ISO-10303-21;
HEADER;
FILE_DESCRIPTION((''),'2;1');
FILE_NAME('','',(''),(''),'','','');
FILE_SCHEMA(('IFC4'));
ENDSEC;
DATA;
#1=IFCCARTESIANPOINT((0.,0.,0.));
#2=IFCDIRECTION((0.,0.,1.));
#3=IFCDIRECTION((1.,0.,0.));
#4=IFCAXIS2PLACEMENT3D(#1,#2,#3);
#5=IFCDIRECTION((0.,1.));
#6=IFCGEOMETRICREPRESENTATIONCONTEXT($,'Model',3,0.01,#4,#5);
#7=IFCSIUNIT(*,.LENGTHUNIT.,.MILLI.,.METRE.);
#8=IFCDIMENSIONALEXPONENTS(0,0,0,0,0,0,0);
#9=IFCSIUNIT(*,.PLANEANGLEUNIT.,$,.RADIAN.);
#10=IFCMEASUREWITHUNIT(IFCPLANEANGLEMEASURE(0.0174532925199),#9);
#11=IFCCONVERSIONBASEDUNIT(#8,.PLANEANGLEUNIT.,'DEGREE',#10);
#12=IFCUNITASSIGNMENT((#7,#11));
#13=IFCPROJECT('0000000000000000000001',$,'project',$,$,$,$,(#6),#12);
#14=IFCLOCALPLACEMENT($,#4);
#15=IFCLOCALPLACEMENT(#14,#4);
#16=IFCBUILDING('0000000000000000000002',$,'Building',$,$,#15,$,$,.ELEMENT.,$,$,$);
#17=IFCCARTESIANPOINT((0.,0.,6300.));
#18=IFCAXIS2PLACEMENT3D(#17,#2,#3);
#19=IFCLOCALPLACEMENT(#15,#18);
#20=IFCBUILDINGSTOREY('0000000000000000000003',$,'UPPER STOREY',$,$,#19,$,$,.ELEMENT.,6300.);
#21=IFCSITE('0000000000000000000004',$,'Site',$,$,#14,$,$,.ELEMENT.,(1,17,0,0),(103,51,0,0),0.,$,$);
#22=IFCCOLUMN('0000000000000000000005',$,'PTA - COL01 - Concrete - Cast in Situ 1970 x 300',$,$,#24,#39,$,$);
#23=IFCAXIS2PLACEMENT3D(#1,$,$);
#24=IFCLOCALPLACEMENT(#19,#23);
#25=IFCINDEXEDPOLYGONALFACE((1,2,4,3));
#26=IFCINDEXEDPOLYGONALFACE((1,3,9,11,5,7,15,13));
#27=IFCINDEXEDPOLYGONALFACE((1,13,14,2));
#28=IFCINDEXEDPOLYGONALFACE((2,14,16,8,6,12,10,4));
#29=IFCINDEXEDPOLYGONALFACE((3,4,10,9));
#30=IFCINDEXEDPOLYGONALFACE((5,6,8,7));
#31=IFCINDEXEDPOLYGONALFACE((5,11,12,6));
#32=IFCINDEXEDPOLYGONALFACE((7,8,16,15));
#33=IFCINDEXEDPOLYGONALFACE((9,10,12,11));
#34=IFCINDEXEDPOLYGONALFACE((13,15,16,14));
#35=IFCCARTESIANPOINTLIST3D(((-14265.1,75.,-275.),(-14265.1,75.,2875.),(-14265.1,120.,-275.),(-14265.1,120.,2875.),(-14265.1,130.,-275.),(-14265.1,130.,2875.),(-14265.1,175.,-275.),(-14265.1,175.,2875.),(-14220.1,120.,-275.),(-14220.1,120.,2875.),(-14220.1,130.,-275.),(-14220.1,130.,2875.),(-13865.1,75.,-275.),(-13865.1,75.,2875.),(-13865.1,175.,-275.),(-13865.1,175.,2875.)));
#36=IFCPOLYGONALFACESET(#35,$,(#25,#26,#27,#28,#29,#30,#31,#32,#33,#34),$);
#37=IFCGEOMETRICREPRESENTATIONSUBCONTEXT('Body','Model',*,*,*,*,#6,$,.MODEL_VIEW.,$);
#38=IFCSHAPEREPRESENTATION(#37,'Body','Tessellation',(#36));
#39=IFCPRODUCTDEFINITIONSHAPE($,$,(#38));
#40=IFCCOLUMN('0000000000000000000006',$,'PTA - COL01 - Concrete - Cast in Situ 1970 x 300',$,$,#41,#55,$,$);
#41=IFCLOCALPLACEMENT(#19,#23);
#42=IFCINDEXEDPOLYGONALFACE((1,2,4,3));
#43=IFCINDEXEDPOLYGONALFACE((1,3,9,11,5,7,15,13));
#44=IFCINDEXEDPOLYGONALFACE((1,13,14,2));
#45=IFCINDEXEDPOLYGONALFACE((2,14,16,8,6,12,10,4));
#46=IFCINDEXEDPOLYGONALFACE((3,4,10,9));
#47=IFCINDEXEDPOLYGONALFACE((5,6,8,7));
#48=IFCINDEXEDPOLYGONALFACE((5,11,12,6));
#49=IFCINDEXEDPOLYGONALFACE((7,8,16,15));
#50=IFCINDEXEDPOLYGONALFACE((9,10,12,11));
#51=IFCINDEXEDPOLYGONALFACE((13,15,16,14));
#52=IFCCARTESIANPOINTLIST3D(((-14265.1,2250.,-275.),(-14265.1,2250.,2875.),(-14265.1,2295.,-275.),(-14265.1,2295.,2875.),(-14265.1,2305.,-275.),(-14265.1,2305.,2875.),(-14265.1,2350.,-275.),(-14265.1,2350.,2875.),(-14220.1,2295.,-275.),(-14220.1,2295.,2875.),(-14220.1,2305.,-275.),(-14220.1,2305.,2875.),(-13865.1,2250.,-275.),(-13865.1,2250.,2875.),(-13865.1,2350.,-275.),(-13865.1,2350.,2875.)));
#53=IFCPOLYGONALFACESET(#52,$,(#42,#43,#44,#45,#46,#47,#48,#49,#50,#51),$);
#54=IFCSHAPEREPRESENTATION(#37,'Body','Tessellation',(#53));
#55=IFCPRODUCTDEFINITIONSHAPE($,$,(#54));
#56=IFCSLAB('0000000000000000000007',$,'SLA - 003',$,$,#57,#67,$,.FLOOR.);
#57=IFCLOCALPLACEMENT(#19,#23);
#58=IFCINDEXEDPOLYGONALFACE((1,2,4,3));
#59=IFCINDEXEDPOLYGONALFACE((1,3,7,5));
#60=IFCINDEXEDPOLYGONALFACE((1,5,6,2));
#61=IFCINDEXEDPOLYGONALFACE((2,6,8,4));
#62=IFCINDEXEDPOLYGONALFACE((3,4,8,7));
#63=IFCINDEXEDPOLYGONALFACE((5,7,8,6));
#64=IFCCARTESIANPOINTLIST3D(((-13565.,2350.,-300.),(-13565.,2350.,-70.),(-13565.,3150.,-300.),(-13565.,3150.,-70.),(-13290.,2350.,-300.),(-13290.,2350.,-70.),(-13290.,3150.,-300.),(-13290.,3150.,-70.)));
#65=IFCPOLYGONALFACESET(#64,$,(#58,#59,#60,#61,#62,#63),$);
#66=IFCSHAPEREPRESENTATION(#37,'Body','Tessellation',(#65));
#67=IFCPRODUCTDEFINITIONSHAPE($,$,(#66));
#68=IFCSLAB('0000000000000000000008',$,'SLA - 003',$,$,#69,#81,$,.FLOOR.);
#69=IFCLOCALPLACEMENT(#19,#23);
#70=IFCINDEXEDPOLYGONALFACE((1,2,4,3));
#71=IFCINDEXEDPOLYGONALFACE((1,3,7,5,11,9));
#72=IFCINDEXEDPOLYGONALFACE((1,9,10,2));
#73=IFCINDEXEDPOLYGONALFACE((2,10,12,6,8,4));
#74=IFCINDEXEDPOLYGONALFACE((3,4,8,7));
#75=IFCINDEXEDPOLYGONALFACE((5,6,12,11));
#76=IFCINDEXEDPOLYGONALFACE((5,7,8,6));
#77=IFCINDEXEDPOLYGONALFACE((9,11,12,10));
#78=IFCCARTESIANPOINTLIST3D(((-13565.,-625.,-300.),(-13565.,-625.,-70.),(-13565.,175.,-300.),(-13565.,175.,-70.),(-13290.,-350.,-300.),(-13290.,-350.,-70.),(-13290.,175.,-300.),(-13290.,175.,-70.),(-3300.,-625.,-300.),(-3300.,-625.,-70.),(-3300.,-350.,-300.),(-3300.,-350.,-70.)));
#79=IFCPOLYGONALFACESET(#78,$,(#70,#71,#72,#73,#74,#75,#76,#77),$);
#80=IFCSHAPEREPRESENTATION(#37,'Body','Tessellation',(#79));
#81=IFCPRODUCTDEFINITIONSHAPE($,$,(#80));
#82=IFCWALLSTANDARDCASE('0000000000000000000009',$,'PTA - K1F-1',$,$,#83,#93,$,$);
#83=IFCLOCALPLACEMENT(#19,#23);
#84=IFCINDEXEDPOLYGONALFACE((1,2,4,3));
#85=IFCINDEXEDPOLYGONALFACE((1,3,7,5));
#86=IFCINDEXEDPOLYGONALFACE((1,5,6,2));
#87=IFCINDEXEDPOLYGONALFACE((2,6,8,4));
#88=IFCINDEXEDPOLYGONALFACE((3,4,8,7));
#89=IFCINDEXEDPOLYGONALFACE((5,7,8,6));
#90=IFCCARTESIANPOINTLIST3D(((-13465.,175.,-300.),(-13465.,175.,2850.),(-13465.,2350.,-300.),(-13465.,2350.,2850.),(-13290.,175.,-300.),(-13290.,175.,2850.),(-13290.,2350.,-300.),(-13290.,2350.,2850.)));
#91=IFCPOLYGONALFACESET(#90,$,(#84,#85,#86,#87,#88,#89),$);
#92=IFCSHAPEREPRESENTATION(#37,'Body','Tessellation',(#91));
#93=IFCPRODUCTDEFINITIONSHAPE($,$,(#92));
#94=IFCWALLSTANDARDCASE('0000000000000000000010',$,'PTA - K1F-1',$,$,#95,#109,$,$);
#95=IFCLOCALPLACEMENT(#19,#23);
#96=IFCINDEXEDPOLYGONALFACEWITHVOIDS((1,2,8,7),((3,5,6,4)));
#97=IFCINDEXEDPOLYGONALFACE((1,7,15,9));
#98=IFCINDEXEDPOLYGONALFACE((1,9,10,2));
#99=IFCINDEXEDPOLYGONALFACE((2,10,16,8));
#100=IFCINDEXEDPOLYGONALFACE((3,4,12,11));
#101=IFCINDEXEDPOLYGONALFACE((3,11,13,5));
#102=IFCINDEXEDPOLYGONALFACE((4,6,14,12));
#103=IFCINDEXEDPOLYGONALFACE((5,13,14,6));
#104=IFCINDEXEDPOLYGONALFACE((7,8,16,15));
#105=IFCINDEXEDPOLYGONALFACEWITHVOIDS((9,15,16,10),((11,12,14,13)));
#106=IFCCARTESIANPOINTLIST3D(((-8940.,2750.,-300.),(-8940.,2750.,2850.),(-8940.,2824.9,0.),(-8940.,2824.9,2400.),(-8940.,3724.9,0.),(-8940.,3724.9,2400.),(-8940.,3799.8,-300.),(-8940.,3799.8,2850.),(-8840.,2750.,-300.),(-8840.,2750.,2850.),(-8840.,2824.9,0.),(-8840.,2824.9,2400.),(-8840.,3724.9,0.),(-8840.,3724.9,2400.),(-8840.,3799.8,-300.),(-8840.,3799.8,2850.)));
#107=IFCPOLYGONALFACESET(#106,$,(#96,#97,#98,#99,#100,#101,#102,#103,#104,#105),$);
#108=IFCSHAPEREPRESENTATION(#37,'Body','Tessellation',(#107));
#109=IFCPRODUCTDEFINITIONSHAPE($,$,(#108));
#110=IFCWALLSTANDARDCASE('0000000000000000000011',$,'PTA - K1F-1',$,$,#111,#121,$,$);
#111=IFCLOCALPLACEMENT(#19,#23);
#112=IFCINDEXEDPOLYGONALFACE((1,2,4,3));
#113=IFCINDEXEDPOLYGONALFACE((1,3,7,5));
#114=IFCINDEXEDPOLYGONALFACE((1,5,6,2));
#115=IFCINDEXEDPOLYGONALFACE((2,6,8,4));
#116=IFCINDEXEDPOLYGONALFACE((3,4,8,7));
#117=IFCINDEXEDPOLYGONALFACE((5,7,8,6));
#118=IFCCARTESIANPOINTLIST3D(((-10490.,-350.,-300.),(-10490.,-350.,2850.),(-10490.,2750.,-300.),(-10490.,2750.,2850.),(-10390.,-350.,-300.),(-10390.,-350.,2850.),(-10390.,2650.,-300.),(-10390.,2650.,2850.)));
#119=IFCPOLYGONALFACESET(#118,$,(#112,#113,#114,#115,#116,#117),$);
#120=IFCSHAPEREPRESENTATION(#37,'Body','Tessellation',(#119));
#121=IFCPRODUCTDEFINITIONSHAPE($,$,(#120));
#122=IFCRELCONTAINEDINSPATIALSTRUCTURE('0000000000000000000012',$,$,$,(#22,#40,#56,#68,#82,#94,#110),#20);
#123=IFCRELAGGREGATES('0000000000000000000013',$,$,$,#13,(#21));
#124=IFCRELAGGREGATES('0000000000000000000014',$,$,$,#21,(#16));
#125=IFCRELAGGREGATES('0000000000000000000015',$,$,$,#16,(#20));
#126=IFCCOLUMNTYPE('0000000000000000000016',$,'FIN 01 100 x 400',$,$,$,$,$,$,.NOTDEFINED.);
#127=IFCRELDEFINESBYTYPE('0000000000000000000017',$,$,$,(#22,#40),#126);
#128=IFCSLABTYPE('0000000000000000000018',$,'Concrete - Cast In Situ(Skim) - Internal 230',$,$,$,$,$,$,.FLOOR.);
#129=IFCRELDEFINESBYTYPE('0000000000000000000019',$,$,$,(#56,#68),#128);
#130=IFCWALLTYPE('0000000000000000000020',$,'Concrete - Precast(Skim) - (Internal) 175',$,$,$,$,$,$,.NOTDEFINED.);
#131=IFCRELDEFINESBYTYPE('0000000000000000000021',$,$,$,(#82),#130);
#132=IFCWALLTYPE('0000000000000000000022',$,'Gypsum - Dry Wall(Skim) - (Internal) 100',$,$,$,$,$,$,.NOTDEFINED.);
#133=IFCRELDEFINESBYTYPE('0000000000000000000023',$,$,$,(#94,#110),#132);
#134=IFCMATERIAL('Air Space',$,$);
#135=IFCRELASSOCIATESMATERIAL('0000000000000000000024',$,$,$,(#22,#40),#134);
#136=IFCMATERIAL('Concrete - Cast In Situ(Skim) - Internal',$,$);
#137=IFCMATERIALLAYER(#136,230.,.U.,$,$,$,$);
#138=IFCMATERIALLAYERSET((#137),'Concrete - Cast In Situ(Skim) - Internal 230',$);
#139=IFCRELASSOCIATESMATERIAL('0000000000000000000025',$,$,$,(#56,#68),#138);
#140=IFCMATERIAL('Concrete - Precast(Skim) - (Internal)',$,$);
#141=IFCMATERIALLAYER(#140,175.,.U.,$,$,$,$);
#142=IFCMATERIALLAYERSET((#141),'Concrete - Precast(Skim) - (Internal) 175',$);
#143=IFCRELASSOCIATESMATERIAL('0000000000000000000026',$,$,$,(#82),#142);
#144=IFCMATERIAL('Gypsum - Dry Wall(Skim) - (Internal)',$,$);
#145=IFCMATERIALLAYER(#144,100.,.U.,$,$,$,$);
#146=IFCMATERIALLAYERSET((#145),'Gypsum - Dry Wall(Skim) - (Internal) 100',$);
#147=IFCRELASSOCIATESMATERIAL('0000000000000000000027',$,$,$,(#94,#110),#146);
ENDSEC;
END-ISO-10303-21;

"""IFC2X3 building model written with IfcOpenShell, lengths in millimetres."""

from ifc_helpers import new_model, entity, si_unit, converted_unit, direction, frame, origin_with_axes, origin_2d_with_axis, place, context, subcontext, project, spatial, polyline, rectangle, outline, extrude, material, layer, layer_set, layer_usage, type_object, element, save


model = new_model("IFC2X3")

# Units and contexts
model_context = context("Model", 3, precision=0.01, world=origin_with_axes(), true_north=direction((0.0, 1.0)))
body_context = subcontext(model_context, "Body", "Model", "MODEL_VIEW")
ifc_project = project(units=[si_unit("LENGTHUNIT", "METRE", prefix="MILLI"), converted_unit("PLANEANGLEUNIT", "DEGREE", entity("IfcPlaneAngleMeasure", 0.0174532925199), si_unit("PLANEANGLEUNIT", "RADIAN"), dimensions=[0, 0, 0, 0, 0, 0, 0])], contexts=[model_context])

# Site, building, storey
site_placement = place(None, origin_with_axes())
site = spatial("IfcSite", under=ifc_project, at=site_placement, Name="Site", CompositionType="ELEMENT", RefLatitude=(1, 17, 0, 0), RefLongitude=(103, 51, 0, 0), RefElevation=0.0)
building_placement = place(site_placement, origin_with_axes())
building = spatial("IfcBuilding", under=site, at=building_placement, Name="Building", CompositionType="ELEMENT")
storey_placement = place(building_placement, frame((0.0, 0.0, 6300.0), z_axis=(0.0, 0.0, 1.0), x_axis=(1.0, 0.0, 0.0)))
storey = spatial("IfcBuildingStorey", under=building, at=storey_placement, Name="UPPER STOREY", CompositionType="ELEMENT", Elevation=6300.0)

# Columns
ifc_material_1 = material(Name="Air Space")
column_type = type_object("IfcColumnType", Name="FIN 01 100 x 400", PredefinedType="NOTDEFINED")
for number, where, z_axis, x_axis, name in (
    (1, (-14265.1, 125.0, -275.0), (0.0, 0.0, 1.0), (0.0, 1.0, 0.0), "PTA - COL01 - Concrete - Cast in Situ 1970 x 300"),
    (2, (-14265.1, 2300.0, -275.0), (0.0, 0.0, 1.0), (0.0, 1.0, 0.0), "PTA - COL01 - Concrete - Cast in Situ 1970 x 300"),
):
    element("IfcColumn", number, at=place(storey_placement, frame(where, z_axis=z_axis, x_axis=x_axis)), inside=storey, type_object=column_type, material=ifc_material_1, Name=name, context=body_context, shape_type="SweptSolid", body=[
        extrude(outline(polyline([(-50.0, 0.0), (-50.0, -400.0), (50.0, -400.0), (50.0, 0.0), (5.0, 0.0), (5.0, -45.0), (-5.0, -45.0), (-5.0, 0.0), (-50.0, 0.0)])), frame((0.0, 0.0, 0.0), z_axis=(0.0, 0.0, -1.0), x_axis=(-1.0, 0.0, 0.0)), (0.0, 0.0, -1.0), 3150.0),
    ])

# Slabs
ifc_material_2 = material(Name="Concrete - Cast In Situ(Skim) - Internal")
ifc_layer_1 = layer(ifc_material_2, 230.0, ventilated="UNKNOWN")
ifc_layer_set_1 = layer_set([ifc_layer_1], Name="Concrete - Cast In Situ(Skim) - Internal 230")
ifc_layer_usage_1 = layer_usage(ifc_layer_set_1, "AXIS3", "NEGATIVE", 230.0)
slab_type = type_object("IfcSlabType", Name="Concrete - Cast In Situ(Skim) - Internal 230", PredefinedType="FLOOR")
slab_1_placement = place(storey_placement, frame((-13565.0, 2350.0, -70.0), z_axis=(0.0, 0.0, 1.0), x_axis=(1.0, 0.0, 0.0)))
element("IfcSlab", 3, at=slab_1_placement, inside=storey, type_object=slab_type, material=ifc_layer_usage_1, Name="SLA - 003", PredefinedType="FLOOR", context=body_context, shape_type="SweptSolid", body=[
    extrude(outline(polyline([(0.0, 0.0), (275.0, 0.0), (275.0, 800.0), (0.0, 800.0), (0.0, 0.0)])), frame((0.0, 0.0, -230.0), z_axis=(0.0, 0.0, 1.0), x_axis=(1.0, 0.0, 0.0)), (0.0, 0.0, 1.0), 230.0),
])
ifc_layer_usage_2 = layer_usage(ifc_layer_set_1, "AXIS3", "NEGATIVE", 230.0)
slab_2_placement = place(storey_placement, frame((-13565.0, 175.0, -70.0), z_axis=(0.0, 0.0, 1.0), x_axis=(1.0, 0.0, 0.0)))
element("IfcSlab", 4, at=slab_2_placement, inside=storey, type_object=slab_type, material=ifc_layer_usage_2, Name="SLA - 003", PredefinedType="FLOOR", context=body_context, shape_type="SweptSolid", body=[
    extrude(outline(polyline([(0.0, 0.0), (0.0, -800.0), (10265.0, -800.0), (10265.0, -525.0), (275.0, -525.0), (275.0, 0.0), (0.0, 0.0)])), frame((0.0, 0.0, -230.0), z_axis=(0.0, 0.0, 1.0), x_axis=(1.0, 0.0, 0.0)), (0.0, 0.0, 1.0), 230.0),
])

# Wall
ifc_material_3 = material(Name="Concrete - Precast(Skim) - (Internal)")
ifc_layer_2 = layer(ifc_material_3, 175.0, ventilated="UNKNOWN")
ifc_layer_set_2 = layer_set([ifc_layer_2], Name="Concrete - Precast(Skim) - (Internal) 175")
ifc_layer_usage_3 = layer_usage(ifc_layer_set_2, "AXIS2", "NEGATIVE", 0.0)
wall_type_1 = type_object("IfcWallType", Name="Concrete - Precast(Skim) - (Internal) 175", PredefinedType="NOTDEFINED")
wall_1_placement = place(storey_placement, frame((-13465.0, 175.0, -300.0), z_axis=(0.0, 0.0, 1.0), x_axis=(0.0, 1.0, 0.0)))
element("IfcWallStandardCase", 5, at=wall_1_placement, inside=storey, type_object=wall_type_1, material=ifc_layer_usage_3, Name="PTA - K1F-1", context=body_context, shape_type="SweptSolid", body=[
    extrude(outline(polyline([(0.0, -175.0), (2175.0, -175.0), (2175.0, 0.0), (0.0, 0.0), (0.0, -175.0)])), origin_with_axes(), (0.0, 0.0, 1.0), 3150.0),
])

# Wall, opening
ifc_material_4 = material(Name="Gypsum - Dry Wall(Skim) - (Internal)")
ifc_layer_3 = layer(ifc_material_4, 100.0, ventilated="UNKNOWN")
ifc_layer_set_3 = layer_set([ifc_layer_3], Name="Gypsum - Dry Wall(Skim) - (Internal) 100")
ifc_layer_usage_4 = layer_usage(ifc_layer_set_3, "AXIS2", "NEGATIVE", 0.0)
wall_type_2 = type_object("IfcWallType", Name="Gypsum - Dry Wall(Skim) - (Internal) 100", PredefinedType="NOTDEFINED")
wall_2_placement = place(storey_placement, frame((-8940.0, 2750.0, -300.0), z_axis=(0.0, 0.0, 1.0), x_axis=(0.000007, 1.0, 0.0)))
wall_2 = element("IfcWallStandardCase", 6, at=wall_2_placement, inside=storey, type_object=wall_type_2, material=ifc_layer_usage_4, Name="PTA - K1F-1", context=body_context, shape_type="SweptSolid", body=[
    extrude(outline(polyline([(0.0, -100.0), (1049.8, -100.0), (1049.8, 0.0), (0.0, 0.0), (0.0, -100.0)])), origin_with_axes(), (0.0, 0.0, 1.0), 3150.0),
])
opening_placement = place(wall_2_placement, frame((524.9, 0.0, 300.0), z_axis=(0.0, 0.0, 1.0), x_axis=(1.0, 0.0, 0.0)))
element("IfcOpeningElement", 7, at=opening_placement, cuts=wall_2, context=body_context, shape_type="SweptSolid", body=[
    extrude(rectangle(XDim=900.0, YDim=2400.0, at=origin_2d_with_axis()), frame((0.0, 100.0, 1200.0), z_axis=(0.0, 1.0, 0.0), x_axis=(-1.0, 0.0, 0.0)), (0.0, 0.0, -1.0), 300.0),
])

# Wall
ifc_layer_usage_5 = layer_usage(ifc_layer_set_3, "AXIS2", "POSITIVE", 0.0)
wall_3_placement = place(storey_placement, frame((-10490.0, 2750.0, -300.0), z_axis=(0.0, 0.0, 1.0), x_axis=(0.0, -1.0, 0.0)))
element("IfcWallStandardCase", 8, at=wall_3_placement, inside=storey, type_object=wall_type_2, material=ifc_layer_usage_5, Name="PTA - K1F-1", context=body_context, shape_type="SweptSolid", body=[
    extrude(outline(polyline([(0.0, 0.0), (3100.0, 0.0), (3100.0, 100.0), (100.0, 100.0), (0.0, 0.0)])), origin_with_axes(), (0.0, 0.0, 1.0), 3150.0),
])

save(model, "model.ifc")
